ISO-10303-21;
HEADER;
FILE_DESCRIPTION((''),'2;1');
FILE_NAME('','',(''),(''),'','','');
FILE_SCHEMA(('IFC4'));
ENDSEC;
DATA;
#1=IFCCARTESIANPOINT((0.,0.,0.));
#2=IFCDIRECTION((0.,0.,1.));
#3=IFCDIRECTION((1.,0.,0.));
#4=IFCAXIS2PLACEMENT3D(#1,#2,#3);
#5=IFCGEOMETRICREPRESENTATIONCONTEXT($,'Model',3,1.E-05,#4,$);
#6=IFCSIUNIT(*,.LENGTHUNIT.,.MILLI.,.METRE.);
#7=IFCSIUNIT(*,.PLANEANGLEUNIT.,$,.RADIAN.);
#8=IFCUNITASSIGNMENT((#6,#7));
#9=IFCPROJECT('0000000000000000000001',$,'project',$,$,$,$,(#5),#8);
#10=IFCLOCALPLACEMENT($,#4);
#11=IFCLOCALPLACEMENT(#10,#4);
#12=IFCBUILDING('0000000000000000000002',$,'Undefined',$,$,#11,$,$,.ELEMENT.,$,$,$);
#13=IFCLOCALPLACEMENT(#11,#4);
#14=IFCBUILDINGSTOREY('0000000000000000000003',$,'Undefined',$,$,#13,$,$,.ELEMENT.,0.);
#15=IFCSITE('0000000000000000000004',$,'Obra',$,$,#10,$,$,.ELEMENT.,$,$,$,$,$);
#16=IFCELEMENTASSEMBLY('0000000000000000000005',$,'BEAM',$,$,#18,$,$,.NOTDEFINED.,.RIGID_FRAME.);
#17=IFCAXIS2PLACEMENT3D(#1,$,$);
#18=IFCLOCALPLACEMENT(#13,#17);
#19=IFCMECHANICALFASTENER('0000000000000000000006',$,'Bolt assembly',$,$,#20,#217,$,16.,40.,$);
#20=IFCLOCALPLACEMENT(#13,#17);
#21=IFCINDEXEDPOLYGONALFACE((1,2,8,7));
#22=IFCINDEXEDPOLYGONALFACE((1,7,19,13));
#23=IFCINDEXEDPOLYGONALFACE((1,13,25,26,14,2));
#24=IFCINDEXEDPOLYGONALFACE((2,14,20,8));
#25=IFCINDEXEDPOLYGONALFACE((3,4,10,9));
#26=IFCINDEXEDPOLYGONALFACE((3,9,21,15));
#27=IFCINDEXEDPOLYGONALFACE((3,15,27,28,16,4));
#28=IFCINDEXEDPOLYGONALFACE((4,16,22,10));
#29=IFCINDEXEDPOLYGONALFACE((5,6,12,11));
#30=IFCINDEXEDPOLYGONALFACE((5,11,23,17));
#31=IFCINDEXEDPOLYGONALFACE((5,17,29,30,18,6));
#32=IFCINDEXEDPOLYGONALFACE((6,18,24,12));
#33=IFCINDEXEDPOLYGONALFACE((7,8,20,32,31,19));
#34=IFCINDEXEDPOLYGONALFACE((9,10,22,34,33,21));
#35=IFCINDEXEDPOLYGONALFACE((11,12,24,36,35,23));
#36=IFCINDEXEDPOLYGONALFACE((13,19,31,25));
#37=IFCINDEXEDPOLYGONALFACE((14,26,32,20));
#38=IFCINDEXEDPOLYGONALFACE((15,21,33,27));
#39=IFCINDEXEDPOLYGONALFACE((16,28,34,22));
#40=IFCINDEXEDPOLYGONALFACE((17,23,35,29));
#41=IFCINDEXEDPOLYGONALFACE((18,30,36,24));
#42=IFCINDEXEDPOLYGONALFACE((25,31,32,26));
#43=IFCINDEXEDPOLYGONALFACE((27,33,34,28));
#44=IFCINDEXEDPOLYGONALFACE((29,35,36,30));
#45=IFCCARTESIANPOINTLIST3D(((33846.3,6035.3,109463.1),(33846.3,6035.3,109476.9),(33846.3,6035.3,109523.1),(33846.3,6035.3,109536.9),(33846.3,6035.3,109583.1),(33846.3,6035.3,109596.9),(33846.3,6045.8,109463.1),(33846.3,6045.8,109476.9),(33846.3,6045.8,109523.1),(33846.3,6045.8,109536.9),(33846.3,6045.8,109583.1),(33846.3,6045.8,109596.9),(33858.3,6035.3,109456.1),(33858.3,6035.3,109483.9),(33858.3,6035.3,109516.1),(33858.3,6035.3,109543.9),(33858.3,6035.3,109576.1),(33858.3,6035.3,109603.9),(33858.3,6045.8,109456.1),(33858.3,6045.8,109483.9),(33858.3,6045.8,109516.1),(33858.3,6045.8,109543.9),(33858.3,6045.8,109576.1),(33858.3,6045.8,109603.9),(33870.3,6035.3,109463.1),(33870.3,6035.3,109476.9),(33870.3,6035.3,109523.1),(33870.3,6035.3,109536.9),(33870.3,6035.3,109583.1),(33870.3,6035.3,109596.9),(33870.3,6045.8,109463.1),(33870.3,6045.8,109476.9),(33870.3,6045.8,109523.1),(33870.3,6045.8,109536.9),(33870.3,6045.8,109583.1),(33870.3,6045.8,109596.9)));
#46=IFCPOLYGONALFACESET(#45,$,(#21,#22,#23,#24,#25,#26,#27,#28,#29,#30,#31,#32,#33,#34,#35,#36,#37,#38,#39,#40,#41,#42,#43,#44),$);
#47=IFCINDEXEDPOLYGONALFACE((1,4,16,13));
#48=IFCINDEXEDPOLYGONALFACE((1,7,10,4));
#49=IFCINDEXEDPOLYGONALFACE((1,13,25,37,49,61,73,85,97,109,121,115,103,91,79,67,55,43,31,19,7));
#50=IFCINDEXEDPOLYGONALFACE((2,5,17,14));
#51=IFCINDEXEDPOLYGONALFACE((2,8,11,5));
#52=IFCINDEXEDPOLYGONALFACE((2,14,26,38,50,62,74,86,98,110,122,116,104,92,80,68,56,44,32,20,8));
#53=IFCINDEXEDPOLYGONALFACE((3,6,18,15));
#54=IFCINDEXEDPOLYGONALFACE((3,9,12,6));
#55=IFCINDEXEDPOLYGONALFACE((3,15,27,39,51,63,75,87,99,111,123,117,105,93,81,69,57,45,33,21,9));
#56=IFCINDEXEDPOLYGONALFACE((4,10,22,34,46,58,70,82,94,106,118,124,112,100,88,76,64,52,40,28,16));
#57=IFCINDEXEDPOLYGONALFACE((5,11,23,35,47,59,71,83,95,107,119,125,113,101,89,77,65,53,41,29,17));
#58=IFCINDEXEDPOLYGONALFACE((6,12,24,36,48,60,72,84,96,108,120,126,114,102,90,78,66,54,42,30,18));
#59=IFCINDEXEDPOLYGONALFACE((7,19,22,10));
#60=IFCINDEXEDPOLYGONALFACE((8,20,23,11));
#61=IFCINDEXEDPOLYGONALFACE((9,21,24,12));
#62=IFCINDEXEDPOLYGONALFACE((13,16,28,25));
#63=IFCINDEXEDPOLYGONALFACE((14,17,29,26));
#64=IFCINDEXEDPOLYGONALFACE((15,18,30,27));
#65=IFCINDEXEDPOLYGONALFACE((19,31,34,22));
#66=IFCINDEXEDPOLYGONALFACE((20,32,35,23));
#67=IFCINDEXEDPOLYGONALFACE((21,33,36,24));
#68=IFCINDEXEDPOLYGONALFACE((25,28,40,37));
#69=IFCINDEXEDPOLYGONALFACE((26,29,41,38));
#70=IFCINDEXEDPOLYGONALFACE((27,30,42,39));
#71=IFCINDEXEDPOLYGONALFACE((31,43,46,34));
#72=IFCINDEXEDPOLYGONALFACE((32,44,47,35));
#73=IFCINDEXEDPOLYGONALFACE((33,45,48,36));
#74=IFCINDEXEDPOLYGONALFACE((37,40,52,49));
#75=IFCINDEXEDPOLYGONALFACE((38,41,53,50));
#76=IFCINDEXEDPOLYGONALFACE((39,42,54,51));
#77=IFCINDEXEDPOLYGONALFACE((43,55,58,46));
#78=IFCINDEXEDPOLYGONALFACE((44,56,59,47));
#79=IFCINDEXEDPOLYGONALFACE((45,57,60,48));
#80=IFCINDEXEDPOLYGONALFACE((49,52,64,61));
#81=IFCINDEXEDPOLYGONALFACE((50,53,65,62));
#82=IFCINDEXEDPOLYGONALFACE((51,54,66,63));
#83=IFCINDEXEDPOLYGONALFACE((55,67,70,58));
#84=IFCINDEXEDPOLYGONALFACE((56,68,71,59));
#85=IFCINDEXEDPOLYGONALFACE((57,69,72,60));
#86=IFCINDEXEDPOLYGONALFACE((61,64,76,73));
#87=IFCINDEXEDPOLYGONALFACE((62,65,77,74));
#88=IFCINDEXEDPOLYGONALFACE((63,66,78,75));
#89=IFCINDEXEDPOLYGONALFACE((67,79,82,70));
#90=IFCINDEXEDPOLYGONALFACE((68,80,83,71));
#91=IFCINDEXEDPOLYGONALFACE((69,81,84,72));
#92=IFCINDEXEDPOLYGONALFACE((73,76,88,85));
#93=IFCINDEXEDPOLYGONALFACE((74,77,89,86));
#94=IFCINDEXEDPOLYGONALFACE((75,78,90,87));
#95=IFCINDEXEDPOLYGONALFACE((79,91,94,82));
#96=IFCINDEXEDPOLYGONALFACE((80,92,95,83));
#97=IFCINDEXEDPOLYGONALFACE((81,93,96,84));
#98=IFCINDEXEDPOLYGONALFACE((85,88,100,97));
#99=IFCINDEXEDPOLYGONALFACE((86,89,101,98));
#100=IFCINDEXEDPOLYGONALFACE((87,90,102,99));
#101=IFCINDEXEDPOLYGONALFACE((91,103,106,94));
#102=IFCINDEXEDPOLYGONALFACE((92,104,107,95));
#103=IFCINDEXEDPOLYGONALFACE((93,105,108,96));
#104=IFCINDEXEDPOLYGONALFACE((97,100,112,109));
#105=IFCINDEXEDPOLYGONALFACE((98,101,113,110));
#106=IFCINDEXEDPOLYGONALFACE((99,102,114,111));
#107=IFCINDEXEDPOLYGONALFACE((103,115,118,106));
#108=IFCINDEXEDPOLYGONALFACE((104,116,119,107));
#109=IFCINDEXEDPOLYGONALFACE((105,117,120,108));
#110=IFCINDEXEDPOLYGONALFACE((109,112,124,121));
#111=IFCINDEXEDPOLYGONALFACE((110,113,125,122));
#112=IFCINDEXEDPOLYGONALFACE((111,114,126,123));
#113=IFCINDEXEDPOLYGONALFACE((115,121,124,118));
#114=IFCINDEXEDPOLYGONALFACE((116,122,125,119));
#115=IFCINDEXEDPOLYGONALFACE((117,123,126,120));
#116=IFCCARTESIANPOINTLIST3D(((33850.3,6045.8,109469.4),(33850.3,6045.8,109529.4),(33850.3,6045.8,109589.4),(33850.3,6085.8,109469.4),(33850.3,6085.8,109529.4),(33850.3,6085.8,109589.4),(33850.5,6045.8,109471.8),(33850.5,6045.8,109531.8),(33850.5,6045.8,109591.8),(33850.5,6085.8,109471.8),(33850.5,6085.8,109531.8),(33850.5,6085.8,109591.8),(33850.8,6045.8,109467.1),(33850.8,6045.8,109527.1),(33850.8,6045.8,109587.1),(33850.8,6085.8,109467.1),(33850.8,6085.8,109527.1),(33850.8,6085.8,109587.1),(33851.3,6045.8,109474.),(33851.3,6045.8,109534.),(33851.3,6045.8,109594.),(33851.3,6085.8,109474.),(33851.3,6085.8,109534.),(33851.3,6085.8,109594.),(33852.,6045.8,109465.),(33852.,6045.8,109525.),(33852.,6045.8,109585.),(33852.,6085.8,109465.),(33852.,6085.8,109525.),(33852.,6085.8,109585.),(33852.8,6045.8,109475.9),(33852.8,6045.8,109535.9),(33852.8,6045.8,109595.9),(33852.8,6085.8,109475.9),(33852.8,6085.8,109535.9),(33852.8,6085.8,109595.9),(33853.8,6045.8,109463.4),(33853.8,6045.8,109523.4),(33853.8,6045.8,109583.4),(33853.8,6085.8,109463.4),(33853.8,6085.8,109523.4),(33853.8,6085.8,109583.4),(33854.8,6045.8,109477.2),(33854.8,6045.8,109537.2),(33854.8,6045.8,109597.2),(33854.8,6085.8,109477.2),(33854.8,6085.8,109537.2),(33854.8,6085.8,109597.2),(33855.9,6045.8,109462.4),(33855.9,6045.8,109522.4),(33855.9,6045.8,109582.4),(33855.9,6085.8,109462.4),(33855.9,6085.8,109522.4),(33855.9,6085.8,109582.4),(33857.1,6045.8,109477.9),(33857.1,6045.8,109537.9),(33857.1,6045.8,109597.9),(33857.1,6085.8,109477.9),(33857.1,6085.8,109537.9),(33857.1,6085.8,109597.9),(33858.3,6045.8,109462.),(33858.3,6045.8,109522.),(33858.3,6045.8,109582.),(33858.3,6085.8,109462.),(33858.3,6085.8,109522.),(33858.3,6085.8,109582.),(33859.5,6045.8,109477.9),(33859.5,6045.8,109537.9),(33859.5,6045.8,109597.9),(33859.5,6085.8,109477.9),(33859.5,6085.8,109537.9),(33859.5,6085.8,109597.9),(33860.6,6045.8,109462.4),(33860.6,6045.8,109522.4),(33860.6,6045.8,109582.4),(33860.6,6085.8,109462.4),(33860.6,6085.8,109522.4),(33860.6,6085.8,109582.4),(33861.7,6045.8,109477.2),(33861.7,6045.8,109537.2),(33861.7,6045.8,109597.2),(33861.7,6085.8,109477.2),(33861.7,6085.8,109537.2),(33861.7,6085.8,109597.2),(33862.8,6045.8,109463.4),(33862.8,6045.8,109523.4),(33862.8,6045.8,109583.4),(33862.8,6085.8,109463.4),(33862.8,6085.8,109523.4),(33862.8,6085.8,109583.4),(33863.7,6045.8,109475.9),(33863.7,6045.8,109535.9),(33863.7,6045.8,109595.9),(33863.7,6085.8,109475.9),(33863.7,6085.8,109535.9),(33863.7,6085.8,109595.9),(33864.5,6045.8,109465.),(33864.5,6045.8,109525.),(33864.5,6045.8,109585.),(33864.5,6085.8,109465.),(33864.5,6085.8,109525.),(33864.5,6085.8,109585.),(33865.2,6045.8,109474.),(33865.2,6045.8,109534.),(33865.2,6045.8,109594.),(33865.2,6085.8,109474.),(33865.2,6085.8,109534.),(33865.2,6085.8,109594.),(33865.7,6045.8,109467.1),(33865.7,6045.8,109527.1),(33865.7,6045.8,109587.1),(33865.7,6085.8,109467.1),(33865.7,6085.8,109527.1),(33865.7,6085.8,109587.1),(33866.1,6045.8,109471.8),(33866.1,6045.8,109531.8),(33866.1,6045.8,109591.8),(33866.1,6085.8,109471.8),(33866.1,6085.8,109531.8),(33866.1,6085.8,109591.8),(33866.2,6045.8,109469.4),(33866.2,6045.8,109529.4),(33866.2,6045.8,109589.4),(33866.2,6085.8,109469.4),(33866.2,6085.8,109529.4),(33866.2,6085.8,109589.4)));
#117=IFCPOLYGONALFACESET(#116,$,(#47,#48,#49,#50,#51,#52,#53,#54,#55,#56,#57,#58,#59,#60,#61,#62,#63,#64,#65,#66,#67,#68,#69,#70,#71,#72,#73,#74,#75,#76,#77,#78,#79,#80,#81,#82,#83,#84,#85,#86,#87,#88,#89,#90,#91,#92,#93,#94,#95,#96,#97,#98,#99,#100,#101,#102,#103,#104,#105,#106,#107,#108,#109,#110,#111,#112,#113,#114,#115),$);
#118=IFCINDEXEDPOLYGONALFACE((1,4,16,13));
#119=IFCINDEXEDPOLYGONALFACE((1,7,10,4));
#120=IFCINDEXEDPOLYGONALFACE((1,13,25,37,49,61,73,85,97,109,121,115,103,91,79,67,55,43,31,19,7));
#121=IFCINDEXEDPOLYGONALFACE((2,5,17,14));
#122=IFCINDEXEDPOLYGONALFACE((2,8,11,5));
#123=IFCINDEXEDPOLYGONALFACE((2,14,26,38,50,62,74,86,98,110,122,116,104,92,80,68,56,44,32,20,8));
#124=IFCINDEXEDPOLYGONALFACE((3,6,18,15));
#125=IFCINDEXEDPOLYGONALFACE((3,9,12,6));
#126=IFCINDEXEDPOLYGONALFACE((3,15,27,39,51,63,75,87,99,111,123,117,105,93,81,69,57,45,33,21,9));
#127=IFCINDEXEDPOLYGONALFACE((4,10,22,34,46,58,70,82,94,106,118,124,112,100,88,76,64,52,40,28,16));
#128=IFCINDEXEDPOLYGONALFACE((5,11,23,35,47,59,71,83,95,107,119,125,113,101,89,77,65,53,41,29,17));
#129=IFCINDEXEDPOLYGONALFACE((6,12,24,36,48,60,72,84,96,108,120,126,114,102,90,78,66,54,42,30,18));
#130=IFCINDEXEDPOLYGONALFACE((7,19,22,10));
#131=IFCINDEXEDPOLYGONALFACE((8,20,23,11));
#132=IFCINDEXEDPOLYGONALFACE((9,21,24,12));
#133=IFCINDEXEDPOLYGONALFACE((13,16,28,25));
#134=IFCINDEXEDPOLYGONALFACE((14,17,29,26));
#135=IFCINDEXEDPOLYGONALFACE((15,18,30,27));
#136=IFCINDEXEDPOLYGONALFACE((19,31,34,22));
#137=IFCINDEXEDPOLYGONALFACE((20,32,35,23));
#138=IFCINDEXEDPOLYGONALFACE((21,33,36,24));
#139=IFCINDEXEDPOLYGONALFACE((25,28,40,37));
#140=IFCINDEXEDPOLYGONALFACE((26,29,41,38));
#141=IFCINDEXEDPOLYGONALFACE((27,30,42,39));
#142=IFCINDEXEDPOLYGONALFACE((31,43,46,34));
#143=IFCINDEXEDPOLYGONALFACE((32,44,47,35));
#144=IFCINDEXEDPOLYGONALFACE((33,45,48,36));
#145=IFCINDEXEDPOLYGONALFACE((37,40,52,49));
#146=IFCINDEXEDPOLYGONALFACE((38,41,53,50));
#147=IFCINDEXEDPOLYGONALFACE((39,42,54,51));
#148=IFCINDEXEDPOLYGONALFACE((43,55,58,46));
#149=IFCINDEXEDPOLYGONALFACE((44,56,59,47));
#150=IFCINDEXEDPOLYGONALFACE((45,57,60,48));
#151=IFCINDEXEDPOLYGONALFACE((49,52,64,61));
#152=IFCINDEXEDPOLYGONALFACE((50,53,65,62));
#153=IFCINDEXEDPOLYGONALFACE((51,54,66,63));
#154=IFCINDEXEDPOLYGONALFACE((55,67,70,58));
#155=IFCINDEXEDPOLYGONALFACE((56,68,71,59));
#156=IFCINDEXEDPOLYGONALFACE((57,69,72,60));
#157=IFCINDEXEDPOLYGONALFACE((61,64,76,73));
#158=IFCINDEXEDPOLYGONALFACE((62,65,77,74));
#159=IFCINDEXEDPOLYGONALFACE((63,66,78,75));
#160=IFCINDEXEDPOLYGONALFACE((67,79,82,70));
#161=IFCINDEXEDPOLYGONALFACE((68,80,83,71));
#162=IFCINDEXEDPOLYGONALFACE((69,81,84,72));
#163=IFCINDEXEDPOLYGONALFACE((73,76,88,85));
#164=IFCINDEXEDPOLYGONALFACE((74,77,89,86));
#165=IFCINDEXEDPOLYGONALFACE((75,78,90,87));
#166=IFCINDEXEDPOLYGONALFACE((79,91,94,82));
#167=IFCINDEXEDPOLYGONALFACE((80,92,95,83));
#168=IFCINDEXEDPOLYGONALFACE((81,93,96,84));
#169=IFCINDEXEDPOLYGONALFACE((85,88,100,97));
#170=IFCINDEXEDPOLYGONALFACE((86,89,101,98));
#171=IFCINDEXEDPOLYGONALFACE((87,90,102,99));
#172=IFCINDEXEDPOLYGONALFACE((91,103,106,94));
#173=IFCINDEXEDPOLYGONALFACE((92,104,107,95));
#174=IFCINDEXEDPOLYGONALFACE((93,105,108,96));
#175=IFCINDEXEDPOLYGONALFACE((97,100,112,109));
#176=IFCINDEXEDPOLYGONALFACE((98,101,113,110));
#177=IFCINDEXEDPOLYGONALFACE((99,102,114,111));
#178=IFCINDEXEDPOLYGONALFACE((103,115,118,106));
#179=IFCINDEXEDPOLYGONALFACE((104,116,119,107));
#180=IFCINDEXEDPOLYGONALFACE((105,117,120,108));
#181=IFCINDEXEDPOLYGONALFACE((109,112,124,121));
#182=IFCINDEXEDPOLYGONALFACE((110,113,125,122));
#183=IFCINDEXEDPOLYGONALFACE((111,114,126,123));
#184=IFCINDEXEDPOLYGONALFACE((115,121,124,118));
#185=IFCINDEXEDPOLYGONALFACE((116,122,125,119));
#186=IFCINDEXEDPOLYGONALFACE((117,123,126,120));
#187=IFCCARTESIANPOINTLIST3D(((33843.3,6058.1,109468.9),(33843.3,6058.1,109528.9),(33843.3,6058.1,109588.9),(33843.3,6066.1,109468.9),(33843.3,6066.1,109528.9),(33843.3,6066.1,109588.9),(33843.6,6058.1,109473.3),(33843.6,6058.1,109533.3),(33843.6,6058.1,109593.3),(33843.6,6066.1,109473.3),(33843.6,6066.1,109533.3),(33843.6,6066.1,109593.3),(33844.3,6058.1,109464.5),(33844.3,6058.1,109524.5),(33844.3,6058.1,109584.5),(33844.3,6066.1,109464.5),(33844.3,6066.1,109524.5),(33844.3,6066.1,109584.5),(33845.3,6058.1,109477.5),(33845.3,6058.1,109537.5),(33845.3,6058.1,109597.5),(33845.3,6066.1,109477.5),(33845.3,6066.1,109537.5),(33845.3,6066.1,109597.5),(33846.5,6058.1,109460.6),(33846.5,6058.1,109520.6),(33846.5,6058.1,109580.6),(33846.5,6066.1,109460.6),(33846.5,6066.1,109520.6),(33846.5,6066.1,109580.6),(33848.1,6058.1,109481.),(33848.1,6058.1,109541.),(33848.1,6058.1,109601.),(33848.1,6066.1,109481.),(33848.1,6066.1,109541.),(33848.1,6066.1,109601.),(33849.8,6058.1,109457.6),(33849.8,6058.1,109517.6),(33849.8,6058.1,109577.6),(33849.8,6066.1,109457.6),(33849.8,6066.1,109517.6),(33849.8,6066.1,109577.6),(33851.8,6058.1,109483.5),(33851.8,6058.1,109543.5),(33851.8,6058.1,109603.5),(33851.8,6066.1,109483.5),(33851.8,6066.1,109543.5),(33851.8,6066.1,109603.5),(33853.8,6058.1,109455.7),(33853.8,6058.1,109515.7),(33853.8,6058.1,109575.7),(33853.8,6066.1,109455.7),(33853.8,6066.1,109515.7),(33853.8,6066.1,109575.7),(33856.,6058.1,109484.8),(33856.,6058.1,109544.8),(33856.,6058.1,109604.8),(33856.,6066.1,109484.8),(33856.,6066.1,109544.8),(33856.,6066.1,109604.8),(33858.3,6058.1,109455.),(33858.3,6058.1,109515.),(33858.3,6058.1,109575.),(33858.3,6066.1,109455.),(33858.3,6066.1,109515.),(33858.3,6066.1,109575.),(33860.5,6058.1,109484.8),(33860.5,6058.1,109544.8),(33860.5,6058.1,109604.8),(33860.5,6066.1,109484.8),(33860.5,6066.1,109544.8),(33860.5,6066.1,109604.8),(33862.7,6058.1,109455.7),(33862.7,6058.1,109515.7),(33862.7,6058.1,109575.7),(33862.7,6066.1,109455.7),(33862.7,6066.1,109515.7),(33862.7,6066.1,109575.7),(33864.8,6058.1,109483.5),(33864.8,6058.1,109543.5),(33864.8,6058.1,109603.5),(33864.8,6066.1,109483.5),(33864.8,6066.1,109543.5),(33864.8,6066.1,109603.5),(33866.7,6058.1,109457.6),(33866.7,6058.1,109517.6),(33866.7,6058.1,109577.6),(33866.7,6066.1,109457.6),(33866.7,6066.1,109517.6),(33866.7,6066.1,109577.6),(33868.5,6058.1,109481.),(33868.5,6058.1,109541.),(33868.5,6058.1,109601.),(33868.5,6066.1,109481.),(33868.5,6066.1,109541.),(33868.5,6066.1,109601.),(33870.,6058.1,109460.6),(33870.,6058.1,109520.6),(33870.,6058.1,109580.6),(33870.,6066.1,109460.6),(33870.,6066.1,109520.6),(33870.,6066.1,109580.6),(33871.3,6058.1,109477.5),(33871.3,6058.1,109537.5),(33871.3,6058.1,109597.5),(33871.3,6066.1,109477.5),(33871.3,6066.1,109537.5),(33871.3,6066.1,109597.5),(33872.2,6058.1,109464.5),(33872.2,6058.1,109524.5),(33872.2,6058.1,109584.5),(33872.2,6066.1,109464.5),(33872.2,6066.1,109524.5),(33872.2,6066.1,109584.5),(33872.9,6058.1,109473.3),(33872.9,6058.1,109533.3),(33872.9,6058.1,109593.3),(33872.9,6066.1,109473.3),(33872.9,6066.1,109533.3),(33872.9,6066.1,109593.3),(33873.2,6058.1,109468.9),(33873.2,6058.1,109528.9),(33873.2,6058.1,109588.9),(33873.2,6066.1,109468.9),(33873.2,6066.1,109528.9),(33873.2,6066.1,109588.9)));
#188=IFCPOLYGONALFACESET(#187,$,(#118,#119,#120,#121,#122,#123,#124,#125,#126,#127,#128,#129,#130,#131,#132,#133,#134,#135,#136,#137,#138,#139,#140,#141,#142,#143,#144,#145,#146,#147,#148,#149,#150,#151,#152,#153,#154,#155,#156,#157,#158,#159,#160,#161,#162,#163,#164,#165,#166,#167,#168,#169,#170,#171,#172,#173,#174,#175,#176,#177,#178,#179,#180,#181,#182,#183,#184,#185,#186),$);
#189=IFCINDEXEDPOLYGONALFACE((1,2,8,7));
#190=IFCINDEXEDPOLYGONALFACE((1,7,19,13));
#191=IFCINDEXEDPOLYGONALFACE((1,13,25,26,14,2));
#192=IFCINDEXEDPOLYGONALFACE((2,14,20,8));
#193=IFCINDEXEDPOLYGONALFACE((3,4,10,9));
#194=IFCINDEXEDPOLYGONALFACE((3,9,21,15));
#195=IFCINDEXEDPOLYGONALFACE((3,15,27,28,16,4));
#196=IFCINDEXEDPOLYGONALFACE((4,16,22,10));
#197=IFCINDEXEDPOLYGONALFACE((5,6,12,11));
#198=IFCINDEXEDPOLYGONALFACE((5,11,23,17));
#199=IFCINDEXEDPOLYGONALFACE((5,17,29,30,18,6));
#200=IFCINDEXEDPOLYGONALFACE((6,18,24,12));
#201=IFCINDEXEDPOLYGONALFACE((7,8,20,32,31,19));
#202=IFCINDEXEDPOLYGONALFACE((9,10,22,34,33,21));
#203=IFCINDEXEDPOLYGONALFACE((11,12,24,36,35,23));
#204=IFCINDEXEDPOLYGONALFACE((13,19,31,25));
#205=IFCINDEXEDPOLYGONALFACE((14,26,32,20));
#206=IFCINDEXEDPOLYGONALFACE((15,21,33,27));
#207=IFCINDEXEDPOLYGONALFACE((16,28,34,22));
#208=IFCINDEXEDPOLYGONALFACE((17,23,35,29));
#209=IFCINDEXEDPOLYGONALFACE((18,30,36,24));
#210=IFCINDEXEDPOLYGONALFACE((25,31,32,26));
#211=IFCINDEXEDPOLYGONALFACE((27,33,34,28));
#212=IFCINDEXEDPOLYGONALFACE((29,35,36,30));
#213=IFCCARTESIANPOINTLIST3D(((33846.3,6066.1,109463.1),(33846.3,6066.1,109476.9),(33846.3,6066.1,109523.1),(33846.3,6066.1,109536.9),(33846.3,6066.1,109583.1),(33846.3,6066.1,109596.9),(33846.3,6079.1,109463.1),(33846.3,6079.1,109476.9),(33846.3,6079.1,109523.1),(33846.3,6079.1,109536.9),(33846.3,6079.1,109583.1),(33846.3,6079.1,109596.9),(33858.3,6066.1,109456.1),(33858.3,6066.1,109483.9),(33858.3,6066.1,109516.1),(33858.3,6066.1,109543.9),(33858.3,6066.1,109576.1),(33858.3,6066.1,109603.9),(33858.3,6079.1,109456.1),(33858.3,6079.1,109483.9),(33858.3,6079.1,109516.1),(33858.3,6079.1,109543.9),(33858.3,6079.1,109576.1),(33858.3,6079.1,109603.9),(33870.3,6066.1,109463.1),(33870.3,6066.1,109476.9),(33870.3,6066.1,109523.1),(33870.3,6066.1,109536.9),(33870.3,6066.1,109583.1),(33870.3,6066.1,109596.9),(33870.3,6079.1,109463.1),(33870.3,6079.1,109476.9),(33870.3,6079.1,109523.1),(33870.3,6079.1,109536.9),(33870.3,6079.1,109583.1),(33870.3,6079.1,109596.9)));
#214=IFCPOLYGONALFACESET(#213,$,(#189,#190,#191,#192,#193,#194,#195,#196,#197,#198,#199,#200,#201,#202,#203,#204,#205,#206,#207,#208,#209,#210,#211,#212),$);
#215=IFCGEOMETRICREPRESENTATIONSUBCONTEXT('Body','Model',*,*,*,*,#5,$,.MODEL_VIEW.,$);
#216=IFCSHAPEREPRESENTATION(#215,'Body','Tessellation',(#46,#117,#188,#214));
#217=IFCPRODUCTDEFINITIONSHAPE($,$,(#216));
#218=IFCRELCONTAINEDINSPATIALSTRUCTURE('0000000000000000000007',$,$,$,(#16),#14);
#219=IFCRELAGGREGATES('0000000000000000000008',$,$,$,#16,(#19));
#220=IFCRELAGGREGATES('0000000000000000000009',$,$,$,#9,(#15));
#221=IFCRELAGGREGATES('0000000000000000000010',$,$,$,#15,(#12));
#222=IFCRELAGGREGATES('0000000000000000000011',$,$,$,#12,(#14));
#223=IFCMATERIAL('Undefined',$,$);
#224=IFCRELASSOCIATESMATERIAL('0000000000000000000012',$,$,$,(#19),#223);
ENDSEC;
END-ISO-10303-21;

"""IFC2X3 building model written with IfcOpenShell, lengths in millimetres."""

from ifc_helpers import new_model, si_unit, frame, origin_with_axes, origin_2d_with_axis, place, context, subcontext, project, spatial, polyline, circle, outline, extrude, source, transform, mapped, material, element, aggregate, save


model = new_model("IFC2X3")

# Units and contexts
model_context = context("Model", 3, precision=1e-05, world=origin_with_axes())
body_context = subcontext(model_context, "Body", "Model", "MODEL_VIEW")
ifc_project = project(units=[si_unit("LENGTHUNIT", "METRE", prefix="MILLI"), si_unit("PLANEANGLEUNIT", "RADIAN")], contexts=[model_context])

# Site, building, storey
site_placement = place(None, origin_with_axes())
site = spatial("IfcSite", under=ifc_project, at=site_placement, Name="Obra", CompositionType="ELEMENT")
building_placement = place(site_placement, origin_with_axes())
building = spatial("IfcBuilding", under=site, at=building_placement, Name="Undefined", CompositionType="ELEMENT")
storey_placement = place(building_placement, origin_with_axes())
storey = spatial("IfcBuildingStorey", under=building, at=storey_placement, Name="Undefined", CompositionType="ELEMENT", Elevation=0.0)

# Element assembly
assembly_1_placement = place(storey_placement, origin_with_axes())
assembly_1 = element("IfcElementAssembly", 1, at=assembly_1_placement, inside=storey, Name="BEAM", AssemblyPlace="NOTDEFINED", PredefinedType="RIGID_FRAME")

# Shared definitions
ifc_material_1 = material(Name="Undefined")

# Shared definitions
shared_shape_1 = source(origin_with_axes(), body_context, "Body", "SweptSolid", [
    extrude(outline(polyline([(13.9, 0.0), (6.9, 12.0), (-6.9, 12.0), (-13.9, 0.0), (-6.9, -12.0), (6.9, -12.0), (13.9, 0.0)])), frame((0.0, -19.7, 0.0), z_axis=(0.0, 1.0, 0.0), x_axis=(1.0, 0.0, 0.0)), (0.0, 0.0, 1.0), 10.6),
    extrude(circle(Radius=8.0, at=origin_2d_with_axis()), frame((0.0, -9.1, 0.0), z_axis=(0.0, 1.0, 0.0), x_axis=(1.0, 0.0, 0.0)), (0.0, 0.0, 1.0), 40.0),
    extrude(circle(Radius=15.0, at=origin_2d_with_axis()), frame((0.0, 3.1, 0.0), z_axis=(0.0, 1.0, 0.0), x_axis=(1.0, 0.0, 0.0)), (0.0, 0.0, 1.0), 8.0),
    extrude(outline(polyline([(13.9, 0.0), (6.9, 12.0), (-6.9, 12.0), (-13.9, 0.0), (-6.9, -12.0), (6.9, -12.0), (13.9, 0.0)])), frame((0.0, 11.1, 0.0), z_axis=(0.0, 1.0, 0.0), x_axis=(1.0, 0.0, 0.0)), (0.0, 0.0, 1.0), 13.0),
])

# Mechanical fastener
mechanical_fastener_1_placement = place(assembly_1_placement, frame((33808.3, 6055.0, 109650.0), z_axis=(1.0, -0.000126, 0.0), x_axis=(0.0, 0.0, -1.0)))
mechanical_fastener_1 = element("IfcMechanicalFastener", 2, at=mechanical_fastener_1_placement, material=ifc_material_1, Name="Bolt assembly", NominalDiameter=16.0, NominalLength=40.0, context=body_context, shape_type="MappedRepresentation", body=[
    mapped(shared_shape_1, transform((60.0, 0.0, 50.0))),
    mapped(shared_shape_1, transform((120.0, 0.0, 50.0))),
    mapped(shared_shape_1, transform((180.0, 0.0, 50.0))),
])
aggregate(assembly_1, [mechanical_fastener_1])

save(model, "model.ifc")
